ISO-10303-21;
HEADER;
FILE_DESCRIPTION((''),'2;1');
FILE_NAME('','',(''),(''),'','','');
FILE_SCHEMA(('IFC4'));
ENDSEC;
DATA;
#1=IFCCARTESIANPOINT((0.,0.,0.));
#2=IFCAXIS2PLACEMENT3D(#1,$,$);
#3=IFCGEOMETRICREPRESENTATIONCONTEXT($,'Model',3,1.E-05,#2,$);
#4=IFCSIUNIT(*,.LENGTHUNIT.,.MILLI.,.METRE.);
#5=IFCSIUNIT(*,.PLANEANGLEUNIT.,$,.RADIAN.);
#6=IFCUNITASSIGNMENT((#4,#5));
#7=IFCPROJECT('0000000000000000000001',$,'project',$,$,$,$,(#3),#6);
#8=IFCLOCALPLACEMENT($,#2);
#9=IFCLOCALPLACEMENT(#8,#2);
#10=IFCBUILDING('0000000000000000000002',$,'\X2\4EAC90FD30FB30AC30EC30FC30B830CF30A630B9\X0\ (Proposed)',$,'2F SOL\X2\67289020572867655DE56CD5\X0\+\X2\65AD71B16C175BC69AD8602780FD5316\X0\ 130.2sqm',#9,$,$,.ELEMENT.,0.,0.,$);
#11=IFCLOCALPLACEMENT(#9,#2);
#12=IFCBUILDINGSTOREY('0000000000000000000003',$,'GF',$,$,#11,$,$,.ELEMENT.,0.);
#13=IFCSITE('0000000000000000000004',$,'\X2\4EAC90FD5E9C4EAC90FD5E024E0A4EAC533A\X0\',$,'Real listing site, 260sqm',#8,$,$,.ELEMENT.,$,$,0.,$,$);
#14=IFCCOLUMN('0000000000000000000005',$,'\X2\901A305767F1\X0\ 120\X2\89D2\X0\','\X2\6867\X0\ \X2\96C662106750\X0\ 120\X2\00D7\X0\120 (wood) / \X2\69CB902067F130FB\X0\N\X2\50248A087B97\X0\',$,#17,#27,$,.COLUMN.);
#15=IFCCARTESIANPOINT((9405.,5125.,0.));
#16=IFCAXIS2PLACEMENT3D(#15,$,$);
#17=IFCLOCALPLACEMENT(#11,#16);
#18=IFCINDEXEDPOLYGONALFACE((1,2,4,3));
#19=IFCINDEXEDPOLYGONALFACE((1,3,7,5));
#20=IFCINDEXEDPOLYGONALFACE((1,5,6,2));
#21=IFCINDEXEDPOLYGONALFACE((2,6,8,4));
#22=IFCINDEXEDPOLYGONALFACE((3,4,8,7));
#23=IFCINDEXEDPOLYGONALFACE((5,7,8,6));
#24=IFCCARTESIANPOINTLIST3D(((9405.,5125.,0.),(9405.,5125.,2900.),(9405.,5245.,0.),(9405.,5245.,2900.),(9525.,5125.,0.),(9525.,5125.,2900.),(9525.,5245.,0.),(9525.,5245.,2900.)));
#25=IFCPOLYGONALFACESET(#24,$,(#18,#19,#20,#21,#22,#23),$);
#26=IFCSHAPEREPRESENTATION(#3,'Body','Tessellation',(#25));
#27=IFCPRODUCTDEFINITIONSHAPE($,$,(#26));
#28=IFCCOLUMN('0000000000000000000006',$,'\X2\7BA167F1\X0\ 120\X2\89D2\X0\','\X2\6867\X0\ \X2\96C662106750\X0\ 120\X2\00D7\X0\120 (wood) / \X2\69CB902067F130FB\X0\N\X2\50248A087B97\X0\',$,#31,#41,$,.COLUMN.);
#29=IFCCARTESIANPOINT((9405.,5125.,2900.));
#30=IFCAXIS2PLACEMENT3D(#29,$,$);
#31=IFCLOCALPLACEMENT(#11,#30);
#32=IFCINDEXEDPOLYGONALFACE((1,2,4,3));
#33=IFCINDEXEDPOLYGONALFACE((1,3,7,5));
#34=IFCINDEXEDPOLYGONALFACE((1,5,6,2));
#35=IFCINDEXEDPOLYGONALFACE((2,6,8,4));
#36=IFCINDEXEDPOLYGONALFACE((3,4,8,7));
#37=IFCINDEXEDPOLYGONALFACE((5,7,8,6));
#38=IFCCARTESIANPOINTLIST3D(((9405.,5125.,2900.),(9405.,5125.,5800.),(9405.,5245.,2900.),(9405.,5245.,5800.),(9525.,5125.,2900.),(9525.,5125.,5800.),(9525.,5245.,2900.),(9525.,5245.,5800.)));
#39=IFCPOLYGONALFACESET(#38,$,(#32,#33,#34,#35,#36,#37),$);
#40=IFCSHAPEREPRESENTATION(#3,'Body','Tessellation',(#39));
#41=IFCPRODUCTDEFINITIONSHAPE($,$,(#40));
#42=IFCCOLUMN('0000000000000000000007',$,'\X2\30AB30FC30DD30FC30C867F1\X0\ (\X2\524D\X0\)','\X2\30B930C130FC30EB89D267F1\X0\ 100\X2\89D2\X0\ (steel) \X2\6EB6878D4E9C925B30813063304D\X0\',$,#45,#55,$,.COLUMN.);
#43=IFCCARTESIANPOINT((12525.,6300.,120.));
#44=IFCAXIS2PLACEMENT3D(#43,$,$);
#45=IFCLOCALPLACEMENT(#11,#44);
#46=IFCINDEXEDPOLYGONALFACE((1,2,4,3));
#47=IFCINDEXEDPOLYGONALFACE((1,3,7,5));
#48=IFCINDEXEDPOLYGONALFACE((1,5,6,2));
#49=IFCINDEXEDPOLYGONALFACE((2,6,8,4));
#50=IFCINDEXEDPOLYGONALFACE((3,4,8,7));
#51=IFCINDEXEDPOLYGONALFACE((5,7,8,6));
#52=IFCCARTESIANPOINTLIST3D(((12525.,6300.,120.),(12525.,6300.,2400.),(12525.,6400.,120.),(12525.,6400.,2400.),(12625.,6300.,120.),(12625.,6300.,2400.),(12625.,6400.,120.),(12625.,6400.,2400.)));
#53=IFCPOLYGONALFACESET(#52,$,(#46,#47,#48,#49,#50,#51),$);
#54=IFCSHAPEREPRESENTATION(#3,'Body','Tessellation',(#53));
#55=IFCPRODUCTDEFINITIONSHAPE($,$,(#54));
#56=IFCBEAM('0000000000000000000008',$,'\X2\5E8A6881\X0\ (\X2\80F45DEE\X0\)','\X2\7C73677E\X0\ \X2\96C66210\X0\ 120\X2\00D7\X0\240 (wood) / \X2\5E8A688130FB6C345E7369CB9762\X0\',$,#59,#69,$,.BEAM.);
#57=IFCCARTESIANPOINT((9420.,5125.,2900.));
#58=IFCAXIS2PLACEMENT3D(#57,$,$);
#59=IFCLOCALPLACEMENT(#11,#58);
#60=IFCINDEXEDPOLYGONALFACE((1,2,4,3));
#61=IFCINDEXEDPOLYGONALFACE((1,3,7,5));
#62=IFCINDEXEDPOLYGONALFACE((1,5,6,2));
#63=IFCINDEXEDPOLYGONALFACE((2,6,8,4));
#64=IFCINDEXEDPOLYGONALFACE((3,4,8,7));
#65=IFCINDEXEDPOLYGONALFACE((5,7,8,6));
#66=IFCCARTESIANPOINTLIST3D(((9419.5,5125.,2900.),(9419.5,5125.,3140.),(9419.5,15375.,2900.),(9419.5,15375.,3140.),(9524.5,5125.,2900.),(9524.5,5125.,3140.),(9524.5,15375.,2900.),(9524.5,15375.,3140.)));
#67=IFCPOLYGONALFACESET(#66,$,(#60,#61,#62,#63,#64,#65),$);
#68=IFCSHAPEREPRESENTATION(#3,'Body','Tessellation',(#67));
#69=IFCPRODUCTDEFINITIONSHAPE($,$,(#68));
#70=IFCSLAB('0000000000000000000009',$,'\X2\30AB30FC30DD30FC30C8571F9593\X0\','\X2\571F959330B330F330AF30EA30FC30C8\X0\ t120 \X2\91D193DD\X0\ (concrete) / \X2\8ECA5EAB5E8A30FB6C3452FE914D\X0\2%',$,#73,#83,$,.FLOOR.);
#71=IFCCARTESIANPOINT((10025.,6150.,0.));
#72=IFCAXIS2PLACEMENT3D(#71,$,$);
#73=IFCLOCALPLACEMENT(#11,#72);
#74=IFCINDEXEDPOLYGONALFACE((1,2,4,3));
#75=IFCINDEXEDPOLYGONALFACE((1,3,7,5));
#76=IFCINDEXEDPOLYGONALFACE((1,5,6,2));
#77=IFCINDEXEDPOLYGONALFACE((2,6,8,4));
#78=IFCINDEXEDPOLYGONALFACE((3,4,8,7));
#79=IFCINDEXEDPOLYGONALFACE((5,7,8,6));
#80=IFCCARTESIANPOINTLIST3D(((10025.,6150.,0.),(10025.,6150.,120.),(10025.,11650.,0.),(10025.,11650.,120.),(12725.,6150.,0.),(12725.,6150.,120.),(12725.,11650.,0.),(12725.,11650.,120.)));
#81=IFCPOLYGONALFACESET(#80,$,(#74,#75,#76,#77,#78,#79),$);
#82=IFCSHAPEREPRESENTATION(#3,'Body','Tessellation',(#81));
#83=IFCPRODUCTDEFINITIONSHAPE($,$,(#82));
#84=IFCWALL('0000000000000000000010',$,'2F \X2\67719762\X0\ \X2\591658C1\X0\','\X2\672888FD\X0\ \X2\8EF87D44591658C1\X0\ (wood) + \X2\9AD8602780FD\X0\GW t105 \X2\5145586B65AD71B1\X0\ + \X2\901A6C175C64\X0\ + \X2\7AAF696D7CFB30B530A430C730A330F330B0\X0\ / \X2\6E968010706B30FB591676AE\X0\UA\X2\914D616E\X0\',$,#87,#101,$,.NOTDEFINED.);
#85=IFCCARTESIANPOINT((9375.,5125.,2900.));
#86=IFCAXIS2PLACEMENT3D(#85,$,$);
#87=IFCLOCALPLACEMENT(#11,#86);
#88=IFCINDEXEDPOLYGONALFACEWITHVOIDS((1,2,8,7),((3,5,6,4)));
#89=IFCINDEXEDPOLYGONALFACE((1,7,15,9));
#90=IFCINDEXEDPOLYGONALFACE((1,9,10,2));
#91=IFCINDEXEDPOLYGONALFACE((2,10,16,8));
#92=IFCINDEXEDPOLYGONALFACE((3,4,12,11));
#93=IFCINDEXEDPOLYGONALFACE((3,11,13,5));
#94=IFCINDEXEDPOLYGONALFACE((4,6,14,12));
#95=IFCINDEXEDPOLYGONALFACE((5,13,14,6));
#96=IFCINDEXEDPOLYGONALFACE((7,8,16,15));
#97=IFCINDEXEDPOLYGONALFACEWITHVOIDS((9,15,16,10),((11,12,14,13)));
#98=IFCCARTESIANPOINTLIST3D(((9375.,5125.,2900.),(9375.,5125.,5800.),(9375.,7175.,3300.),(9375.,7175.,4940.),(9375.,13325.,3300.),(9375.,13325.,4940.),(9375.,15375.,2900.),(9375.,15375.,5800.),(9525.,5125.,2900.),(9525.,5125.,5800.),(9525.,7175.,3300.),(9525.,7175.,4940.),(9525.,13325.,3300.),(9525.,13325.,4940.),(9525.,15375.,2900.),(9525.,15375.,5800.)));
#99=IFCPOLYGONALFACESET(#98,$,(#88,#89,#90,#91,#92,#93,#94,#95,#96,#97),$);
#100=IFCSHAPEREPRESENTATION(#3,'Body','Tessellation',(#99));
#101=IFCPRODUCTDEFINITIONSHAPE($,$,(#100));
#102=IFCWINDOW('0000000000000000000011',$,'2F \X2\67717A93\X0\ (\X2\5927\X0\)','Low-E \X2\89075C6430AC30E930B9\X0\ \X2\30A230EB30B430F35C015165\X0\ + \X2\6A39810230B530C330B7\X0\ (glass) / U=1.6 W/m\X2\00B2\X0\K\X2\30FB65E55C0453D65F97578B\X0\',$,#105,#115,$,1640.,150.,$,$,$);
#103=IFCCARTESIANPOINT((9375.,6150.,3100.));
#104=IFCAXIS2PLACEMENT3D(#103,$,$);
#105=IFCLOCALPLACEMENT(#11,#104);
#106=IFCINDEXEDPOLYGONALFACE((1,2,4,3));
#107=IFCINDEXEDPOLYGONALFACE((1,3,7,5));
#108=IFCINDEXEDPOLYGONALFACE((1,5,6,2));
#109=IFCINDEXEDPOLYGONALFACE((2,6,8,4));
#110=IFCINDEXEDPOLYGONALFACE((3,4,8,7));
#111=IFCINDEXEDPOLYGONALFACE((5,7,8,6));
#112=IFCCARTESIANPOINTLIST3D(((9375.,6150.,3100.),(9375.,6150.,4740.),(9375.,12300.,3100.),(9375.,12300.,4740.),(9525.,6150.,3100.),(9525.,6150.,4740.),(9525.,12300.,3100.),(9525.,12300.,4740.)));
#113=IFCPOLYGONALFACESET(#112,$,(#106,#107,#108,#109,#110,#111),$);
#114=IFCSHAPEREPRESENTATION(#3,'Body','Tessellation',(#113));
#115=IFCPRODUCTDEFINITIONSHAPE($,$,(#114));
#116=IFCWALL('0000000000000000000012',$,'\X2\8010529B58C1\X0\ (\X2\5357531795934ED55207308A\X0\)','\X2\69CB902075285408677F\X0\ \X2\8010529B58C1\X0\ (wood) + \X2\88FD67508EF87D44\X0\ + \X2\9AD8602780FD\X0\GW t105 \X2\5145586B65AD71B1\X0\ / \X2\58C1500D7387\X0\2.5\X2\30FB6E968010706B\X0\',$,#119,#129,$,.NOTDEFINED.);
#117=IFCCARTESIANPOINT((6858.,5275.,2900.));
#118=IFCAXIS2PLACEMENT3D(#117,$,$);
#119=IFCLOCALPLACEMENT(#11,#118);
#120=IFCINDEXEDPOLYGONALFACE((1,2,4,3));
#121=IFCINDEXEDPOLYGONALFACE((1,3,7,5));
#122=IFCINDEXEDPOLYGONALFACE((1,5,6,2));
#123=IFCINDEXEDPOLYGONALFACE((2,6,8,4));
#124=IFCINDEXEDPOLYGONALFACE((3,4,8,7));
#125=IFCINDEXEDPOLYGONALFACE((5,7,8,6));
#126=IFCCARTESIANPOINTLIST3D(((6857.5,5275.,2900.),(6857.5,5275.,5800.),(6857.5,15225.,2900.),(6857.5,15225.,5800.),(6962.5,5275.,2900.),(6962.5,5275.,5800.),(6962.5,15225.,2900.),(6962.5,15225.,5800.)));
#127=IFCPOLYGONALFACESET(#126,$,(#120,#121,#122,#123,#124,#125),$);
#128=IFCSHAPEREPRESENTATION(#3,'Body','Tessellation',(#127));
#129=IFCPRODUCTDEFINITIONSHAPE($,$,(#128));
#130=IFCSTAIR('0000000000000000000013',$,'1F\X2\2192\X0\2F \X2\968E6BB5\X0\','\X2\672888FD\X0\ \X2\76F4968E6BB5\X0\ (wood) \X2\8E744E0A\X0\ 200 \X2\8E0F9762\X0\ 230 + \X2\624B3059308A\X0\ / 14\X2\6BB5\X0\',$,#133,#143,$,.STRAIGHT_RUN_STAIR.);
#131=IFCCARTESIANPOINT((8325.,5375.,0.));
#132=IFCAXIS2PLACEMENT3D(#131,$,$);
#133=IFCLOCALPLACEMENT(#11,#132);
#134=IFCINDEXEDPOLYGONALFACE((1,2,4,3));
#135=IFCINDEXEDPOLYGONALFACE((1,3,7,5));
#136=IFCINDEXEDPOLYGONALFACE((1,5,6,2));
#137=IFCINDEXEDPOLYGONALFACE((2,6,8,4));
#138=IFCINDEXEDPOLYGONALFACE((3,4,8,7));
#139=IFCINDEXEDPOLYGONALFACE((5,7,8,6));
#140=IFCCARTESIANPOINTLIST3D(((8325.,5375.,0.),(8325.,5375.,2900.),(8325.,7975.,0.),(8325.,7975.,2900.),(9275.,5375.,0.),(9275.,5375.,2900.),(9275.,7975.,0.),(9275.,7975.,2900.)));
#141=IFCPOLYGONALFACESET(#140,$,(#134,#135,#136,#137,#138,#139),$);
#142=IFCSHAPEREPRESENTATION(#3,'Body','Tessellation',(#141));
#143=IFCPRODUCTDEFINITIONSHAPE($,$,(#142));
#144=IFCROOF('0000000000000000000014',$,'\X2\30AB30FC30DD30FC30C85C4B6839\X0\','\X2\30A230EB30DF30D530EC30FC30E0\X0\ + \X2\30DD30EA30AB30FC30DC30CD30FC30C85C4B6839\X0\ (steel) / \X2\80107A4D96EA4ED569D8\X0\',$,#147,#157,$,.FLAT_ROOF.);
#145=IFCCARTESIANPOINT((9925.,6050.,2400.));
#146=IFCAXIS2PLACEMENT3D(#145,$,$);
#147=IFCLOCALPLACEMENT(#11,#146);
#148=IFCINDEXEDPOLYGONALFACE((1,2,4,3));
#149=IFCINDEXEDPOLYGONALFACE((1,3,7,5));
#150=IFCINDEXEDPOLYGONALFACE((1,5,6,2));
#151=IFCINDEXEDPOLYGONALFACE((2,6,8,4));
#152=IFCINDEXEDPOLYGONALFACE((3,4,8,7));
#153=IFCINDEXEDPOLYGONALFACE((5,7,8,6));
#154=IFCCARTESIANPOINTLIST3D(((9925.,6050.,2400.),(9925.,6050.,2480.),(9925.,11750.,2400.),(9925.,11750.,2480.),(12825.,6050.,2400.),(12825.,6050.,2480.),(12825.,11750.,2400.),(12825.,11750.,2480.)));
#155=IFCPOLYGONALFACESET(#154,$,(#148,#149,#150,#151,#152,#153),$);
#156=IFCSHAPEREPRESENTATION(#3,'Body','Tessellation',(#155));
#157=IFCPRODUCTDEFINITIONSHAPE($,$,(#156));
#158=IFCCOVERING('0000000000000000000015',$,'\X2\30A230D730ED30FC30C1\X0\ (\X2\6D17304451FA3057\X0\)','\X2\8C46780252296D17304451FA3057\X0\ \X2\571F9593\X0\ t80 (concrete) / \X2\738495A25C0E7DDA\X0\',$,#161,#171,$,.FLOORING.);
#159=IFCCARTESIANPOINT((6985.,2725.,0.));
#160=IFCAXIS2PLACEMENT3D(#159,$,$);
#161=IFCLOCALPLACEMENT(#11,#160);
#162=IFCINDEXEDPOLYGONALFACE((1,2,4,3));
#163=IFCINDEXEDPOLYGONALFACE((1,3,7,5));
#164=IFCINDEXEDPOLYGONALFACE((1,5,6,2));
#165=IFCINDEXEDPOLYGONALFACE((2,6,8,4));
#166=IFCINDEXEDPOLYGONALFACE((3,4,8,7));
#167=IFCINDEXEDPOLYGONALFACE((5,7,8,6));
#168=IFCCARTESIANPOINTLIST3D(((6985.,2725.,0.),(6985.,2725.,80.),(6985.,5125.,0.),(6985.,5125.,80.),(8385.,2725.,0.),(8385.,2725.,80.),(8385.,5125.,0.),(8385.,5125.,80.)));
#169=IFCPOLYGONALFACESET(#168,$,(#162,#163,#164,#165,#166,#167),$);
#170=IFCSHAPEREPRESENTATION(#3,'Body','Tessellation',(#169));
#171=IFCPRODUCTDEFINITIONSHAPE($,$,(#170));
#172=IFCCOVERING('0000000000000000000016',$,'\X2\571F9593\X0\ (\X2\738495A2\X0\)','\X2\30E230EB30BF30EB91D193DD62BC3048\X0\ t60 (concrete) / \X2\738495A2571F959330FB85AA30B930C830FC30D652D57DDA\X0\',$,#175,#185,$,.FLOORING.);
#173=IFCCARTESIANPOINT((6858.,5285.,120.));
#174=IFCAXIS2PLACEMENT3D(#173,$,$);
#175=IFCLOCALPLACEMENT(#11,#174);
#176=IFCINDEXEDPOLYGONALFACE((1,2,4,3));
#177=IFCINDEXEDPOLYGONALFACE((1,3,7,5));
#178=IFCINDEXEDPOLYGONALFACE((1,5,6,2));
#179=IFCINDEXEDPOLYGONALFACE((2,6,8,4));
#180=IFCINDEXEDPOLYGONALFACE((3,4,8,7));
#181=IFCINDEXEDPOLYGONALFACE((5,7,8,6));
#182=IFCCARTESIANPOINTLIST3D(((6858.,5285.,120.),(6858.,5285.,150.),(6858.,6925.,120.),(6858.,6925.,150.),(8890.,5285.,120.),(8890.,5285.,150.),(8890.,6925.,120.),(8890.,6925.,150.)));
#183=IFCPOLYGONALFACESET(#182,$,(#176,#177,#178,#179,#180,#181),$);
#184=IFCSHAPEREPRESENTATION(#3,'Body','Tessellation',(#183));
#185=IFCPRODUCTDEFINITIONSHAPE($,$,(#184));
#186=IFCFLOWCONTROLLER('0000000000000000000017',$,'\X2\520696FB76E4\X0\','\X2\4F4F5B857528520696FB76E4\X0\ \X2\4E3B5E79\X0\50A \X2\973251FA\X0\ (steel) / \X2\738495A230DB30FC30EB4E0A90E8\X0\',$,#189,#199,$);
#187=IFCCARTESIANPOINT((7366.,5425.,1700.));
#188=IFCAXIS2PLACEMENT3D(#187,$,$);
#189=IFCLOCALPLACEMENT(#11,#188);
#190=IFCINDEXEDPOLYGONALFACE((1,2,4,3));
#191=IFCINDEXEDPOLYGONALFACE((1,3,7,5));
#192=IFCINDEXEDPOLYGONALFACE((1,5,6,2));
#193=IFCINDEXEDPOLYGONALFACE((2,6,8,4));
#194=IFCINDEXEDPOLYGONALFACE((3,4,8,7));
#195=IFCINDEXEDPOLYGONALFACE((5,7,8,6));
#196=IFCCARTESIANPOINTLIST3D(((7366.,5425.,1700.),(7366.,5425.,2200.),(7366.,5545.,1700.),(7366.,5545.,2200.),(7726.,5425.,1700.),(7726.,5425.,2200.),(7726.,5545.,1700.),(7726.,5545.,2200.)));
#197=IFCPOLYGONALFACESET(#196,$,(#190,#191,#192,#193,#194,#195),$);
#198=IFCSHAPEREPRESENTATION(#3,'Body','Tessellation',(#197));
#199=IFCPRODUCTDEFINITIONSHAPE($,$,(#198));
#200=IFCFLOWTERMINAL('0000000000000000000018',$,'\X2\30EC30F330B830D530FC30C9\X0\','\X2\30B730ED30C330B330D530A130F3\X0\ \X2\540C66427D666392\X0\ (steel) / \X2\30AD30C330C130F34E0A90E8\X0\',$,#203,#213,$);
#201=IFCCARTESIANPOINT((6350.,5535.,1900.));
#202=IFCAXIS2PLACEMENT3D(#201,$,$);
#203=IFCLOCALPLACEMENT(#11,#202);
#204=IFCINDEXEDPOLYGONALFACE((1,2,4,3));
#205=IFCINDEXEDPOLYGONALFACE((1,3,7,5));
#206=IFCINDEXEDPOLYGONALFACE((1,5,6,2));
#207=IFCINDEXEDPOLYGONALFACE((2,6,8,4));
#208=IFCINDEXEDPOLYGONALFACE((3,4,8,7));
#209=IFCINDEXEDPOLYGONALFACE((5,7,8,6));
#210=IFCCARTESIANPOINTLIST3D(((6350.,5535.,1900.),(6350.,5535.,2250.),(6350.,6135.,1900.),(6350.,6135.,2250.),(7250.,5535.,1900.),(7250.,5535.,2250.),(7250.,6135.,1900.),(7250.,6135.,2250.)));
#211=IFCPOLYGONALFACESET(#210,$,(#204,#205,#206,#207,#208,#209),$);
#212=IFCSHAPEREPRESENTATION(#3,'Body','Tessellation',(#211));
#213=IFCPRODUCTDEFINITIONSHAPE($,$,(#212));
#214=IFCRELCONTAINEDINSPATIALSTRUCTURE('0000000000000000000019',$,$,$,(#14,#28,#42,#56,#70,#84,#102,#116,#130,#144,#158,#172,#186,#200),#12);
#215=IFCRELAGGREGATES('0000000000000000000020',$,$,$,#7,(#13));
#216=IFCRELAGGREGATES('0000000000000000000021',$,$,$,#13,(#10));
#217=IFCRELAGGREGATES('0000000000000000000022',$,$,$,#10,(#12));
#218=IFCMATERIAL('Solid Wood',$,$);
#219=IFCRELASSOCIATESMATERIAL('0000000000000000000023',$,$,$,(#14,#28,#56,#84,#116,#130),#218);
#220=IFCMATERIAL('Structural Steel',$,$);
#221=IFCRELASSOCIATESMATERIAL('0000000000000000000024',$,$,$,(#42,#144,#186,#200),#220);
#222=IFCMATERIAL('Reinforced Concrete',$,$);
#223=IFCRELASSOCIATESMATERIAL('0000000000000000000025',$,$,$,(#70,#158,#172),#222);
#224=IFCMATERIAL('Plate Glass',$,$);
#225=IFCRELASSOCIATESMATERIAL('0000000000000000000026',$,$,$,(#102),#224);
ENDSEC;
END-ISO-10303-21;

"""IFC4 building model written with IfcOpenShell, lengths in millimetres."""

from ifc_helpers import new_model, si_unit, frame, frame_2d, origin, place, context, project, spatial, rectangle, extrude, material, element, fill, save


model = new_model("IFC4")

# Units and contexts
model_context = context("Model", 3, precision=1e-05, world=origin())
ifc_project = project(units=[si_unit("LENGTHUNIT", "METRE", prefix="MILLI"), si_unit("PLANEANGLEUNIT", "RADIAN")], contexts=[model_context])

# Site, building, storey
site_placement = place(None, origin())
site = spatial("IfcSite", under=ifc_project, at=site_placement, Name="京都府京都市上京区", ObjectType="Real listing site, 260sqm", CompositionType="ELEMENT", RefElevation=0.0)
building_placement = place(site_placement, origin())
building = spatial("IfcBuilding", under=site, at=building_placement, Name="京都・ガレージハウス (Proposed)", ObjectType="2F SOL木造在来工法+断熱気密高性能化 130.2sqm", CompositionType="ELEMENT", ElevationOfRefHeight=0.0, ElevationOfTerrain=0.0)
storey_placement = place(building_placement, origin())
storey = spatial("IfcBuildingStorey", under=building, at=storey_placement, Name="GF", CompositionType="ELEMENT", Elevation=0.0)

# Columns
ifc_material_1 = material(Name="Solid Wood")
column_1_placement = place(storey_placement, frame((9405.0, 5125.0, 0.0)))
element("IfcColumn", 1, at=column_1_placement, inside=storey, material=ifc_material_1, Name="通し柱 120角", Description="桧 集成材 120×120 (wood) / 構造柱・N値計算", PredefinedType="COLUMN", context=model_context, shape_type="SweptSolid", body=[
    extrude(rectangle(XDim=120.0, YDim=120.0, at=frame_2d((60.0, 60.0))), frame((9405.0, 5125.0, 0.0)), (0.0, 0.0, 1.0), 2900.0),
])
column_2_placement = place(storey_placement, frame((9405.0, 5125.0, 2900.0)))
element("IfcColumn", 2, at=column_2_placement, inside=storey, material=ifc_material_1, Name="管柱 120角", Description="桧 集成材 120×120 (wood) / 構造柱・N値計算", PredefinedType="COLUMN", context=model_context, shape_type="SweptSolid", body=[
    extrude(rectangle(XDim=120.0, YDim=120.0, at=frame_2d((60.0, 60.0))), frame((9405.0, 5125.0, 2900.0)), (0.0, 0.0, 1.0), 2900.0),
])
ifc_material_2 = material(Name="Structural Steel")
column_3_placement = place(storey_placement, frame((12525.0, 6300.0, 120.0)))
element("IfcColumn", 3, at=column_3_placement, inside=storey, material=ifc_material_2, Name="カーポート柱 (前)", Description="スチール角柱 100角 (steel) 溶融亜鉛めっき", PredefinedType="COLUMN", context=model_context, shape_type="SweptSolid", body=[
    extrude(rectangle(XDim=100.0, YDim=100.0, at=frame_2d((50.0, 50.0))), frame((12525.0, 6300.0, 120.0)), (0.0, 0.0, 1.0), 2280.0),
])

# Beam
beam_1_placement = place(storey_placement, frame((9420.0, 5125.0, 2900.0)))
element("IfcBeam", 4, at=beam_1_placement, inside=storey, material=ifc_material_1, Name="床梁 (胴差)", Description="米松 集成 120×240 (wood) / 床梁・水平構面", PredefinedType="BEAM", context=model_context, shape_type="SweptSolid", body=[
    extrude(rectangle(XDim=105.0, YDim=10250.0, at=frame_2d((52.0, 5125.0))), frame((9420.0, 5125.0, 2900.0)), (0.0, 0.0, 1.0), 240.0),
])

# Slab
ifc_material_3 = material(Name="Reinforced Concrete")
slab_placement = place(storey_placement, frame((10025.0, 6150.0, 0.0)))
element("IfcSlab", 5, at=slab_placement, inside=storey, material=ifc_material_3, Name="カーポート土間", Description="土間コンクリート t120 金鏝 (concrete) / 車庫床・水勾配2%", PredefinedType="FLOOR", context=model_context, shape_type="SweptSolid", body=[
    extrude(rectangle(XDim=2700.0, YDim=5500.0, at=frame_2d((1350.0, 2750.0))), frame((10025.0, 6150.0, 0.0)), (0.0, 0.0, 1.0), 120.0),
])

# Shared definitions
ifc_material_4 = material(Name="Plate Glass")

# Wall, opening, window
wall_1_placement = place(storey_placement, frame((9375.0, 5125.0, 2900.0)))
wall_1 = element("IfcWall", 6, at=wall_1_placement, inside=storey, material=ifc_material_1, Name="2F 東面 外壁", Description="木製 軸組外壁 (wood) + 高性能GW t105 充填断熱 + 通気層 + 窯業系サイディング / 準耐火・外皮UA配慮", PredefinedType="NOTDEFINED", context=model_context, shape_type="SweptSolid", body=[
    extrude(rectangle(XDim=150.0, YDim=10250.0, at=frame_2d((75.0, 5125.0))), frame((9375.0, 5125.0, 2900.0)), (0.0, 0.0, 1.0), 2900.0),
])
opening_1_placement = place(storey_placement, frame((9375.0, 6150.0, 3100.0)))
opening_1 = element("IfcOpeningElement", 7, at=opening_1_placement, cuts=wall_1, PredefinedType="NOTDEFINED", context=model_context, shape_type="SweptSolid", body=[
    extrude(rectangle(XDim=150.0, YDim=6150.0, at=frame_2d((75.0, 3075.0))), frame((9375.0, 6150.0, 3100.0)), (0.0, 0.0, 1.0), 1640.0),
])
window_1_placement = place(storey_placement, frame((9375.0, 6150.0, 3100.0)))
window_1 = element("IfcWindow", 8, at=window_1_placement, inside=storey, material=ifc_material_4, Name="2F 東窓 (大)", Description="Low-E 複層ガラス アルゴン封入 + 樹脂サッシ (glass) / U=1.6 W/m²K・日射取得型", OverallHeight=1640.0, OverallWidth=150.0, context=model_context, shape_type="SweptSolid", body=[
    extrude(rectangle(XDim=150.0, YDim=6150.0, at=frame_2d((75.0, 3075.0))), frame((9375.0, 6150.0, 3100.0)), (0.0, 0.0, 1.0), 1640.0),
])
fill(opening_1, window_1)

# Wall
wall_2_placement = place(storey_placement, frame((6858.0, 5275.0, 2900.0)))
element("IfcWall", 9, at=wall_2_placement, inside=storey, material=ifc_material_1, Name="耐力壁 (南北間仕切り)", Description="構造用合板 耐力壁 (wood) + 製材軸組 + 高性能GW t105 充填断熱 / 壁倍率2.5・準耐火", PredefinedType="NOTDEFINED", context=model_context, shape_type="SweptSolid", body=[
    extrude(rectangle(XDim=105.0, YDim=9950.0, at=frame_2d((52.0, 4975.0))), frame((6858.0, 5275.0, 2900.0)), (0.0, 0.0, 1.0), 2900.0),
])

# Stair
stair_placement = place(storey_placement, frame((8325.0, 5375.0, 0.0)))
element("IfcStair", 10, at=stair_placement, inside=storey, material=ifc_material_1, Name="1F→2F 階段", Description="木製 直階段 (wood) 蹴上 200 踏面 230 + 手すり / 14段", PredefinedType="STRAIGHT_RUN_STAIR", context=model_context, shape_type="SweptSolid", body=[
    extrude(rectangle(XDim=950.0, YDim=2600.0, at=frame_2d((475.0, 1300.0))), frame((8325.0, 5375.0, 0.0)), (0.0, 0.0, 1.0), 2900.0),
])

# Roof
roof_placement = place(storey_placement, frame((9925.0, 6050.0, 2400.0)))
element("IfcRoof", 11, at=roof_placement, inside=storey, material=ifc_material_2, Name="カーポート屋根", Description="アルミフレーム + ポリカーボネート屋根 (steel) / 耐積雪仕様", PredefinedType="FLAT_ROOF", context=model_context, shape_type="SweptSolid", body=[
    extrude(rectangle(XDim=2900.0, YDim=5700.0, at=frame_2d((1450.0, 2850.0))), frame((9925.0, 6050.0, 2400.0)), (0.0, 0.0, 1.0), 80.0),
])

# Coverings
covering_1_placement = place(storey_placement, frame((6985.0, 2725.0, 0.0)))
element("IfcCovering", 12, at=covering_1_placement, inside=storey, material=ifc_material_3, Name="アプローチ (洗い出し)", Description="豆砂利洗い出し 土間 t80 (concrete) / 玄関導線", PredefinedType="FLOORING", context=model_context, shape_type="SweptSolid", body=[
    extrude(rectangle(XDim=1400.0, YDim=2400.0, at=frame_2d((700.0, 1200.0))), frame((6985.0, 2725.0, 0.0)), (0.0, 0.0, 1.0), 80.0),
])
covering_2_placement = place(storey_placement, frame((6858.0, 5285.0, 120.0)))
element("IfcCovering", 13, at=covering_2_placement, inside=storey, material=ifc_material_3, Name="土間 (玄関)", Description="モルタル金鏝押え t60 (concrete) / 玄関土間・薪ストーブ動線", PredefinedType="FLOORING", context=model_context, shape_type="SweptSolid", body=[
    extrude(rectangle(XDim=2032.0, YDim=1640.0, at=frame_2d((1016.0, 820.0))), frame((6858.0, 5285.0, 120.0)), (0.0, 0.0, 1.0), 30.0),
])

# Flow controller
flow_controller_placement = place(storey_placement, frame((7366.0, 5425.0, 1700.0)))
element("IfcFlowController", 14, at=flow_controller_placement, inside=storey, material=ifc_material_2, Name="分電盤", Description="住宅用分電盤 主幹50A 露出 (steel) / 玄関ホール上部", context=model_context, shape_type="SweptSolid", body=[
    extrude(rectangle(XDim=360.0, YDim=120.0, at=frame_2d((180.0, 60.0))), frame((7366.0, 5425.0, 1700.0)), (0.0, 0.0, 1.0), 500.0),
])

# Flow terminal
flow_terminal_1_placement = place(storey_placement, frame((6350.0, 5535.0, 1900.0)))
element("IfcFlowTerminal", 15, at=flow_terminal_1_placement, inside=storey, material=ifc_material_2, Name="レンジフード", Description="シロッコファン 同時給排 (steel) / キッチン上部", context=model_context, shape_type="SweptSolid", body=[
    extrude(rectangle(XDim=900.0, YDim=600.0, at=frame_2d((450.0, 300.0))), frame((6350.0, 5535.0, 1900.0)), (0.0, 0.0, 1.0), 350.0),
])

save(model, "model.ifc")
